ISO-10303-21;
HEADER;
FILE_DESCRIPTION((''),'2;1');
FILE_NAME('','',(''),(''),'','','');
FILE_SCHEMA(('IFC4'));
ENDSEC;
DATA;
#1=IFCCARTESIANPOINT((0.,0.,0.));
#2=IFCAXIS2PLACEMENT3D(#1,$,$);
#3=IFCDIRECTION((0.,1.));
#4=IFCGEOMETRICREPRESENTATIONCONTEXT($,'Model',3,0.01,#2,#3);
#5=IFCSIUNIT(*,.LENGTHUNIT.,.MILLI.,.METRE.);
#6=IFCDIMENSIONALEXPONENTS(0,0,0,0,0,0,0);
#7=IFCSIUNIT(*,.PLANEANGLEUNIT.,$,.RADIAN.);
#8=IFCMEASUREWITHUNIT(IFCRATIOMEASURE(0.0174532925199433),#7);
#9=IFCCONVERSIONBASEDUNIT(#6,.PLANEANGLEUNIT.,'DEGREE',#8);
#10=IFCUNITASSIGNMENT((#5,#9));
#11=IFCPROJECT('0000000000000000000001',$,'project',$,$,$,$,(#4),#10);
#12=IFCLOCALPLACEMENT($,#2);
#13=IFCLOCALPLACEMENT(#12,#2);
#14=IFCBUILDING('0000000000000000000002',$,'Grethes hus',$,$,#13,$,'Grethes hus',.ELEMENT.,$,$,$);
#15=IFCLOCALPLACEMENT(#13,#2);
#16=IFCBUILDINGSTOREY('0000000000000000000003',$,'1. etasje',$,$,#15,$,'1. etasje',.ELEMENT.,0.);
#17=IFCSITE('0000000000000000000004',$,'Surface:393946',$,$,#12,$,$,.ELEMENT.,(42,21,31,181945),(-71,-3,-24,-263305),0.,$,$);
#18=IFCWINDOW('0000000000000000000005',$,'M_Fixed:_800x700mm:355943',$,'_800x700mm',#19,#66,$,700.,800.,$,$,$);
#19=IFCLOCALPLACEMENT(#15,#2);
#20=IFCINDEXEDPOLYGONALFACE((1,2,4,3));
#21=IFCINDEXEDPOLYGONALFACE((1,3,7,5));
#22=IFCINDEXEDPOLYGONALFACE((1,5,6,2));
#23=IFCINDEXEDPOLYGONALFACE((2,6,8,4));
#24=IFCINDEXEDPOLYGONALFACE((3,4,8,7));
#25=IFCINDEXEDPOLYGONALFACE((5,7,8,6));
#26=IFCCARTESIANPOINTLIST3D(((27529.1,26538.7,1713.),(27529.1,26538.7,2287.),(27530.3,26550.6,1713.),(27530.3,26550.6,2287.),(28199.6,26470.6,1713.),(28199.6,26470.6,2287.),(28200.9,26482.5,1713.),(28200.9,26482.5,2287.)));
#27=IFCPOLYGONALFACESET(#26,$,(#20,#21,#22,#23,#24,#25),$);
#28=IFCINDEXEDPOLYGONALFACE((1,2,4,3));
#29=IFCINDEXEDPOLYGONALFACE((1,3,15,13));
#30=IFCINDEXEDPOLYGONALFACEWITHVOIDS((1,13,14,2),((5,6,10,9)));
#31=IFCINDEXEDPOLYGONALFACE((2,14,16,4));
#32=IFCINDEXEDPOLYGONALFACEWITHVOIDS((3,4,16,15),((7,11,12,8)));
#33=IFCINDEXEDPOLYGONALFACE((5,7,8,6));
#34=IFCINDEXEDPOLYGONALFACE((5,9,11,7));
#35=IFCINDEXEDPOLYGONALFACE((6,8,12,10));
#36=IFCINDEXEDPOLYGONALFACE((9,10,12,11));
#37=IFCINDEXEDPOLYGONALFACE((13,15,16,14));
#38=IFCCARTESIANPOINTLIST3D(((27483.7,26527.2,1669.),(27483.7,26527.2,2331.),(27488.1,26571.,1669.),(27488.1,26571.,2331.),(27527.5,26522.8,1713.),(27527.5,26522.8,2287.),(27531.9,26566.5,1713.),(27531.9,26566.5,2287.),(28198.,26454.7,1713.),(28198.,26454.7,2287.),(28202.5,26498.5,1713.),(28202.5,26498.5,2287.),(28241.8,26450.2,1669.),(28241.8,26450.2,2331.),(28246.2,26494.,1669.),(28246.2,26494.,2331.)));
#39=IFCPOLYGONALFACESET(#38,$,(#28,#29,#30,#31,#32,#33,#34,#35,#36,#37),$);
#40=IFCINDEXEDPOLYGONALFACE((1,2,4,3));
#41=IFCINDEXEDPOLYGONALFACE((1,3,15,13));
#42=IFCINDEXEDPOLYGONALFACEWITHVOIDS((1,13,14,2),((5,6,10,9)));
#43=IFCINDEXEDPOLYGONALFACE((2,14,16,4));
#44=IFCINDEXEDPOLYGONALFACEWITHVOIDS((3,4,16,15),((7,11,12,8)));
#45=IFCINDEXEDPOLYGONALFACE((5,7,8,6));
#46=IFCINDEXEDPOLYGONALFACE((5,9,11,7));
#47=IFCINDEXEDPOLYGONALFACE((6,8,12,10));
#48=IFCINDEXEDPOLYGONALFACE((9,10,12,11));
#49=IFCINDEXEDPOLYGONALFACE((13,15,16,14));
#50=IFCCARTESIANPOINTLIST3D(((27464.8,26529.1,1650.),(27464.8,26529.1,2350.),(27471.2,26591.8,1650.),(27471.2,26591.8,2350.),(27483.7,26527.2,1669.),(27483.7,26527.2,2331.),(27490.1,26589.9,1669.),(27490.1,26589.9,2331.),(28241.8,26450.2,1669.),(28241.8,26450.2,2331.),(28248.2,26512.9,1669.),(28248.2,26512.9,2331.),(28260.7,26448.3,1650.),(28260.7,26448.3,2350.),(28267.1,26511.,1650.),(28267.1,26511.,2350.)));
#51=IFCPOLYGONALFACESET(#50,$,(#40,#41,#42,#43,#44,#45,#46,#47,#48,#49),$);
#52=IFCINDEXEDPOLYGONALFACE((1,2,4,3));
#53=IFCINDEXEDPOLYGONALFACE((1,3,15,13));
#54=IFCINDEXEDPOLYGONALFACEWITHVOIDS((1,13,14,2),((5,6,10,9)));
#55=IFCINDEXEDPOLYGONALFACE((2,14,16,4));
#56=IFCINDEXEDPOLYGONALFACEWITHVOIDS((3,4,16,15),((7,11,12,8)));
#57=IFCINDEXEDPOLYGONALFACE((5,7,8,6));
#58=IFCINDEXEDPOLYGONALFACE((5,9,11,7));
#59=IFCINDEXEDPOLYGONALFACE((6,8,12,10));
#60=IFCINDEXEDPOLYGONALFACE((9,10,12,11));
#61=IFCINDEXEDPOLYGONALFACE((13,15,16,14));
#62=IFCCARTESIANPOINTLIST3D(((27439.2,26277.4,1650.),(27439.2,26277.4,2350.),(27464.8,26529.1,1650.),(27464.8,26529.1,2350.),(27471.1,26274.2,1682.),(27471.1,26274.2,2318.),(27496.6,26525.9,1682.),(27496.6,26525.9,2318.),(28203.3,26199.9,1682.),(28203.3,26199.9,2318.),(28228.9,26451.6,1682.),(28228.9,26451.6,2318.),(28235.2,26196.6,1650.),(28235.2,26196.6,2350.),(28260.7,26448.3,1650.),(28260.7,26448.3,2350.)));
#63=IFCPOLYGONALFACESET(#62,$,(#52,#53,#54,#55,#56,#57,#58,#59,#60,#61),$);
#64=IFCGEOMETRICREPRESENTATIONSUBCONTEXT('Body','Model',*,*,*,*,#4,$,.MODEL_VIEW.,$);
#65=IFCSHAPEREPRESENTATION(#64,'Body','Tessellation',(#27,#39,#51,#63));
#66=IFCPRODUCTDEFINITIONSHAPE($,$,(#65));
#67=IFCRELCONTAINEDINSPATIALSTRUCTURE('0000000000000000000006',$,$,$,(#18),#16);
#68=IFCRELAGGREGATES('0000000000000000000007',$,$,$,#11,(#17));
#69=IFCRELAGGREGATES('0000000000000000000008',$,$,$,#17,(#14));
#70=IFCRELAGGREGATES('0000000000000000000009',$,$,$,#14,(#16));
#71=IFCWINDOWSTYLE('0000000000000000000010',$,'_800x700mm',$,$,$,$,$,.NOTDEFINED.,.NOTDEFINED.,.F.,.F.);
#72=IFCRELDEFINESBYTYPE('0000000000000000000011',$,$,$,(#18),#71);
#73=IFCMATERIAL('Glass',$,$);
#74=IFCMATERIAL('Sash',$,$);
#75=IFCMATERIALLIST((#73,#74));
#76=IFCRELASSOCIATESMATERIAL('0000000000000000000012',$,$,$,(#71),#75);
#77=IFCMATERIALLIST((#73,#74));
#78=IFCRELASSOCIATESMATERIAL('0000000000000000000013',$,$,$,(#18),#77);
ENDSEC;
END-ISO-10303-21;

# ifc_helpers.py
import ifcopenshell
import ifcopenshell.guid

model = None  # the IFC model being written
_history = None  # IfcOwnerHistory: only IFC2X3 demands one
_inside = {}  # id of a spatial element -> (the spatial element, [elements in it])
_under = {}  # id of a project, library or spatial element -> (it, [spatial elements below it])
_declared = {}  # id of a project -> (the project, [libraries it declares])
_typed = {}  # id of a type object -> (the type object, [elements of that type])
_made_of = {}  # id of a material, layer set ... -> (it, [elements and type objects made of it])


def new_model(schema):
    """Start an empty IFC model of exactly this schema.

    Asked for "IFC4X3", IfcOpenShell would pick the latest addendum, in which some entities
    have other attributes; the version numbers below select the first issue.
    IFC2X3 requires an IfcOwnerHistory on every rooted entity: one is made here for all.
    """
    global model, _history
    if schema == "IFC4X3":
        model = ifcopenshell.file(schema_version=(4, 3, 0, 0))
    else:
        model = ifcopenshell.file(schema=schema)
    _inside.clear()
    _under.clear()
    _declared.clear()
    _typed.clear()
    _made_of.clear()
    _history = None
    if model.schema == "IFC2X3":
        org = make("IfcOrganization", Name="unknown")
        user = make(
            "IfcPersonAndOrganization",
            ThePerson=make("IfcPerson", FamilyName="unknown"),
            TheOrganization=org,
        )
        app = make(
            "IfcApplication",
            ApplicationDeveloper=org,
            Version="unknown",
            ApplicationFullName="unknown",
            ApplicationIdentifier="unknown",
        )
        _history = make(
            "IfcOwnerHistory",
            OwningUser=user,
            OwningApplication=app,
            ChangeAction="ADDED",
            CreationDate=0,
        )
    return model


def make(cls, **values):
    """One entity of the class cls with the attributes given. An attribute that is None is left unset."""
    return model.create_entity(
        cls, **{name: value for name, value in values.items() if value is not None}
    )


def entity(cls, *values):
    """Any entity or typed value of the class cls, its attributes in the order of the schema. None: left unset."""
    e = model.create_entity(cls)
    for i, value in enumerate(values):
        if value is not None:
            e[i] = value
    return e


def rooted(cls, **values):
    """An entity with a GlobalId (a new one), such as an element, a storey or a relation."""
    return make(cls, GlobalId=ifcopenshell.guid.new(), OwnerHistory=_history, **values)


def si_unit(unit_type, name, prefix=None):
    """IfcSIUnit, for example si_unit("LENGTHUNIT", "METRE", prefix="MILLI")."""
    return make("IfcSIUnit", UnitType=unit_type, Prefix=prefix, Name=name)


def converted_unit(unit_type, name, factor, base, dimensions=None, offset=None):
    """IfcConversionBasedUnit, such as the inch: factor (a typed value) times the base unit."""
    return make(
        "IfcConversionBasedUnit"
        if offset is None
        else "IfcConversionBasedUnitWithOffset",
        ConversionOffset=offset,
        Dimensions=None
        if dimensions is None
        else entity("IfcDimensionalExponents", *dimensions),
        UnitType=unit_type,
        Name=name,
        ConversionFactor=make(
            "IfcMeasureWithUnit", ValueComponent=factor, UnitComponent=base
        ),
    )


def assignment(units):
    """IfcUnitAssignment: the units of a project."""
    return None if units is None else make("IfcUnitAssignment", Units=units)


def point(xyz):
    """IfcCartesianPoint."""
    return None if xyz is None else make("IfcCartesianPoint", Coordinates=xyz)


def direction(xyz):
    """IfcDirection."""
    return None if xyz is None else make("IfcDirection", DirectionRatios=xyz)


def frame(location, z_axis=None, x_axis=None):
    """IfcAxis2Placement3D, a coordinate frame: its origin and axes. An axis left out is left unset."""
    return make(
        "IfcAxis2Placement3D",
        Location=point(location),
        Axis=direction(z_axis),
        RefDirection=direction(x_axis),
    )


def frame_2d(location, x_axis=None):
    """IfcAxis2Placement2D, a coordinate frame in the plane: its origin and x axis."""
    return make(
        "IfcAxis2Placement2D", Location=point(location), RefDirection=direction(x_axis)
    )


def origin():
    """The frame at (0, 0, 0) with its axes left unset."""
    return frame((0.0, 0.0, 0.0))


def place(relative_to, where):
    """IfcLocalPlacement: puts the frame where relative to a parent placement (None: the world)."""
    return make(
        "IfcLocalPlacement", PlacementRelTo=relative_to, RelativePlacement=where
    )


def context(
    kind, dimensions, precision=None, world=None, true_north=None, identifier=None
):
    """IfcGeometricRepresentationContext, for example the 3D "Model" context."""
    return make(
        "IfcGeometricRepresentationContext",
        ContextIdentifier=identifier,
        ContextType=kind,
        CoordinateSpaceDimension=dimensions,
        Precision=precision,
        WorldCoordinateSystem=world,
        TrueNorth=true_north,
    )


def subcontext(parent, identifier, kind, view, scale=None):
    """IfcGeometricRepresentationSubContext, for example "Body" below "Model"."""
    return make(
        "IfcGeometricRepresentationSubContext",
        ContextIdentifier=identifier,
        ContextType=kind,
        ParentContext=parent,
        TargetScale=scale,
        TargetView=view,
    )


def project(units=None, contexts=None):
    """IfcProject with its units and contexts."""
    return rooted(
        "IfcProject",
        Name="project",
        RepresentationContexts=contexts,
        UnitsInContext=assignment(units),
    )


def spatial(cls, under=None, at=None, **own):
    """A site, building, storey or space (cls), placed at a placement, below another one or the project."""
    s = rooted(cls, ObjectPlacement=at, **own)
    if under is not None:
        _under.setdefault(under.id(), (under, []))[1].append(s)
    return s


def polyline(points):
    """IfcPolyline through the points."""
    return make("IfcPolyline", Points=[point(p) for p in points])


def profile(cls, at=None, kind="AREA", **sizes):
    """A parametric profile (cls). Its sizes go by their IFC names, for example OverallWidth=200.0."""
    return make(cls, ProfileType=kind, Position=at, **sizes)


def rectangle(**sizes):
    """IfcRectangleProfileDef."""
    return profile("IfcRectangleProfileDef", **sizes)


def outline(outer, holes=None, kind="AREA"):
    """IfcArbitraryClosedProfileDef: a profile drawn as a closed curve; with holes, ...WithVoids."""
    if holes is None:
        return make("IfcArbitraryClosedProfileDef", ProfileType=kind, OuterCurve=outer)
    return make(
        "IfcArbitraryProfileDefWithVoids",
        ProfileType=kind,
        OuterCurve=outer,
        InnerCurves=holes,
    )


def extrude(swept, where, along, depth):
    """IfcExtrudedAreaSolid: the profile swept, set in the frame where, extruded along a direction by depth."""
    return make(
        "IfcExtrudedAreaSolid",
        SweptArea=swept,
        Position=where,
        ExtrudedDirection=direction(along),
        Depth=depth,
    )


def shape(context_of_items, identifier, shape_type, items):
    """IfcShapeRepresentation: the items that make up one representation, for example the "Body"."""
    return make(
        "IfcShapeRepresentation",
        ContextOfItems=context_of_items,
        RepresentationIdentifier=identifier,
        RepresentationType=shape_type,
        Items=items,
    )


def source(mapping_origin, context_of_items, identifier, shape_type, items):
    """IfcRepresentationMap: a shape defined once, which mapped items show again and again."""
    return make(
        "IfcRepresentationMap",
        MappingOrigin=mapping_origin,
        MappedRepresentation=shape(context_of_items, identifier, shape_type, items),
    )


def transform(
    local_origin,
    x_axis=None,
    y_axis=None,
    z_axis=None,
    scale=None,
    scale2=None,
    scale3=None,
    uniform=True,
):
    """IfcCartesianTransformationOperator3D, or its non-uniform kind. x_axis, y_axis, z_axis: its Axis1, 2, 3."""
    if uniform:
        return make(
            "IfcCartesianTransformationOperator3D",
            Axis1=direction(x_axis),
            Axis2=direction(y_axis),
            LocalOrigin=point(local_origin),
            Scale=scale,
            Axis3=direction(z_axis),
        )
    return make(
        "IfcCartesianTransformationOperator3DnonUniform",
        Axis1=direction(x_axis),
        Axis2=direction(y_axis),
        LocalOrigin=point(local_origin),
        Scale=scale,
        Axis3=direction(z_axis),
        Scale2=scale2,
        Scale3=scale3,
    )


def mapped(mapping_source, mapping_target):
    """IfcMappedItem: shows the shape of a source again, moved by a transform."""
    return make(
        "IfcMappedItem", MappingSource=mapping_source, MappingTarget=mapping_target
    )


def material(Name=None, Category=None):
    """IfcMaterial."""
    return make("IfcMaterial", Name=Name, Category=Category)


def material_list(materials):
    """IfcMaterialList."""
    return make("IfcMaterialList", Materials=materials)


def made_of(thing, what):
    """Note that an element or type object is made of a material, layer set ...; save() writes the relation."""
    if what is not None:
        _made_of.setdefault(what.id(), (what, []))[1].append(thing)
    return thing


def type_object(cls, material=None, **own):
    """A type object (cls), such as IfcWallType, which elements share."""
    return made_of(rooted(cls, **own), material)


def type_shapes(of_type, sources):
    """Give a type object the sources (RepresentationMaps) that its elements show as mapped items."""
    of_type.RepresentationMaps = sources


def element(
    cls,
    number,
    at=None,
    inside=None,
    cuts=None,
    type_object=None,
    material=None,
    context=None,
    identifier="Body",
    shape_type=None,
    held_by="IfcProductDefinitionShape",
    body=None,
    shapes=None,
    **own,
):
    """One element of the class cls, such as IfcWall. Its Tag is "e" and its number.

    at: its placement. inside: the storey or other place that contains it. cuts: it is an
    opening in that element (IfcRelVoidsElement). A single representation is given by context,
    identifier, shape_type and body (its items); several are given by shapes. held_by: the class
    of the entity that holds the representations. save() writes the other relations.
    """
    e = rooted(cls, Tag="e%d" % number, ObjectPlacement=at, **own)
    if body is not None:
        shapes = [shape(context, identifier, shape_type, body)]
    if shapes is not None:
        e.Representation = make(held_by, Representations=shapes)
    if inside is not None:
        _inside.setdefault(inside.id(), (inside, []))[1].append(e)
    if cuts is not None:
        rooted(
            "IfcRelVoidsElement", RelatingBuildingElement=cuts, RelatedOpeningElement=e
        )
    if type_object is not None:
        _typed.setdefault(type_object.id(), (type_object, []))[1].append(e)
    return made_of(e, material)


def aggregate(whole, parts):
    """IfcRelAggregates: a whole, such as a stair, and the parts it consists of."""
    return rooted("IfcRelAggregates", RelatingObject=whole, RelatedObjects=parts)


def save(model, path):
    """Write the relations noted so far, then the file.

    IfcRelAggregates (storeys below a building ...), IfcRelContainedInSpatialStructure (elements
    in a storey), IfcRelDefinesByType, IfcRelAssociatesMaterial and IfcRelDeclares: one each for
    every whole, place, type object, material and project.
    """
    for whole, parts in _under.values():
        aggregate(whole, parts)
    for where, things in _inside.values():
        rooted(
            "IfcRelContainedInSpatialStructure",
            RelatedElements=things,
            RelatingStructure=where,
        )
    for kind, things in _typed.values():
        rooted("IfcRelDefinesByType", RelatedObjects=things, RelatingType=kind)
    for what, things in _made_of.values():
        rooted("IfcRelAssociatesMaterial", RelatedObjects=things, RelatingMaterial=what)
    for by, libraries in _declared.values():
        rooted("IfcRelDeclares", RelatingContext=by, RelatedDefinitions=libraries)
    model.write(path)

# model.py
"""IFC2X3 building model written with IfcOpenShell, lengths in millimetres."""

from ifc_helpers import new_model, entity, si_unit, converted_unit, direction, frame, frame_2d, origin, place, context, subcontext, project, spatial, polyline, rectangle, outline, extrude, source, transform, mapped, material, material_list, type_object, type_shapes, element, save


model = new_model("IFC2X3")

# Units and contexts
model_context = context("Model", 3, precision=0.01, world=origin(), true_north=direction((0.0, 1.0)))
body_context = subcontext(model_context, "Body", "Model", "MODEL_VIEW")
ifc_project = project(units=[si_unit("LENGTHUNIT", "METRE", prefix="MILLI"), converted_unit("PLANEANGLEUNIT", "DEGREE", entity("IfcRatioMeasure", 0.0174532925199433), si_unit("PLANEANGLEUNIT", "RADIAN"), dimensions=[0, 0, 0, 0, 0, 0, 0])], contexts=[model_context])

# Site, building, storey
site_placement = place(None, origin())
site = spatial("IfcSite", under=ifc_project, at=site_placement, Name="Surface:393946", CompositionType="ELEMENT", RefLatitude=(42, 21, 31, 181945), RefLongitude=(-71, -3, -24, -263305), RefElevation=0.0)
building_placement = place(site_placement, origin())
building = spatial("IfcBuilding", under=site, at=building_placement, Name="Grethes hus", LongName="Grethes hus", CompositionType="ELEMENT")
storey_placement = place(building_placement, origin())
storey = spatial("IfcBuildingStorey", under=building, at=storey_placement, Name="1. etasje", LongName="1. etasje", CompositionType="ELEMENT", Elevation=0.0)

# Shared definitions
ifc_material_1 = material(Name="Glass")
ifc_material_2 = material(Name="Sash")
placement_1 = place(storey_placement, frame((17757.0, 27419.1, 400.0), z_axis=(0.0, 0.0, 1.0), x_axis=(0.994887, -0.100996, 0.0)))

# Window
ifc_material_list_1 = material_list([ifc_material_1, ifc_material_2])
ifc_material_list_2 = material_list([ifc_material_1, ifc_material_2])
window_style_1 = type_object("IfcWindowStyle", Name="_800x700mm", ConstructionType="NOTDEFINED", OperationType="NOTDEFINED", ParameterTakesPrecedence=False, Sizeable=False, material=ifc_material_list_2)
shared_shape_1 = source(origin(), body_context, "Body", "SweptSolid", [
    extrude(rectangle(XDim=674.0, YDim=12.0, at=frame_2d((0.0, 0.0), x_axis=(1.0, 0.0))), frame((400.0, 301.0, 63.0), z_axis=(0.0, 0.0, 1.0), x_axis=(-1.0, 0.0, 0.0)), (0.0, 0.0, 1.0), 574.0),
    extrude(outline(polyline([(-381.0, -331.0), (381.0, -331.0), (381.0, 331.0), (-381.0, 331.0), (-381.0, -331.0)]), holes=[polyline([(-337.0, -287.0), (-337.0, 287.0), (337.0, 287.0), (337.0, -287.0), (-337.0, -287.0)])]), frame((400.0, 323.0, 350.0), z_axis=(0.0, -1.0, 0.0), x_axis=(-1.0, 0.0, 0.0)), (0.0, 0.0, 1.0), 44.0),
    extrude(outline(polyline([(-400.0, -350.0), (400.0, -350.0), (400.0, 350.0), (-400.0, 350.0), (-400.0, -350.0)]), holes=[polyline([(-381.0, -331.0), (-381.0, 331.0), (381.0, 331.0), (381.0, -331.0), (-381.0, -331.0)])]), frame((400.0, 342.0, 350.0), z_axis=(0.0, -1.0, 0.0), x_axis=(-1.0, 0.0, 0.0)), (0.0, 0.0, 1.0), 63.0),
    extrude(outline(polyline([(-400.0, -350.0), (400.0, -350.0), (400.0, 350.0), (-400.0, 350.0), (-400.0, -350.0)]), holes=[polyline([(-368.0, -318.0), (-368.0, 318.0), (368.0, 318.0), (368.0, -318.0), (-368.0, -318.0)])]), frame((400.0, 279.0, 350.0), z_axis=(0.0, -1.0, 0.0), x_axis=(-1.0, 0.0, 0.0)), (0.0, 0.0, 1.0), 253.0),
])
type_shapes(window_style_1, [shared_shape_1])
placement_2 = place(placement_1, frame((9748.0, -158.0, 1250.0)))
window_1_placement = place(placement_2, frame((0.0, -26.0, 0.0)))
element("IfcWindow", 1, at=window_1_placement, inside=storey, type_object=window_style_1, material=ifc_material_list_1, Name="M_Fixed:_800x700mm:355943", ObjectType="_800x700mm", OverallHeight=700.0, OverallWidth=800.0, context=body_context, shape_type="MappedRepresentation", body=[
    mapped(shared_shape_1, transform((0.0, 0.0, 0.0), scale=1.0)),
])

save(model, "model.ifc")
